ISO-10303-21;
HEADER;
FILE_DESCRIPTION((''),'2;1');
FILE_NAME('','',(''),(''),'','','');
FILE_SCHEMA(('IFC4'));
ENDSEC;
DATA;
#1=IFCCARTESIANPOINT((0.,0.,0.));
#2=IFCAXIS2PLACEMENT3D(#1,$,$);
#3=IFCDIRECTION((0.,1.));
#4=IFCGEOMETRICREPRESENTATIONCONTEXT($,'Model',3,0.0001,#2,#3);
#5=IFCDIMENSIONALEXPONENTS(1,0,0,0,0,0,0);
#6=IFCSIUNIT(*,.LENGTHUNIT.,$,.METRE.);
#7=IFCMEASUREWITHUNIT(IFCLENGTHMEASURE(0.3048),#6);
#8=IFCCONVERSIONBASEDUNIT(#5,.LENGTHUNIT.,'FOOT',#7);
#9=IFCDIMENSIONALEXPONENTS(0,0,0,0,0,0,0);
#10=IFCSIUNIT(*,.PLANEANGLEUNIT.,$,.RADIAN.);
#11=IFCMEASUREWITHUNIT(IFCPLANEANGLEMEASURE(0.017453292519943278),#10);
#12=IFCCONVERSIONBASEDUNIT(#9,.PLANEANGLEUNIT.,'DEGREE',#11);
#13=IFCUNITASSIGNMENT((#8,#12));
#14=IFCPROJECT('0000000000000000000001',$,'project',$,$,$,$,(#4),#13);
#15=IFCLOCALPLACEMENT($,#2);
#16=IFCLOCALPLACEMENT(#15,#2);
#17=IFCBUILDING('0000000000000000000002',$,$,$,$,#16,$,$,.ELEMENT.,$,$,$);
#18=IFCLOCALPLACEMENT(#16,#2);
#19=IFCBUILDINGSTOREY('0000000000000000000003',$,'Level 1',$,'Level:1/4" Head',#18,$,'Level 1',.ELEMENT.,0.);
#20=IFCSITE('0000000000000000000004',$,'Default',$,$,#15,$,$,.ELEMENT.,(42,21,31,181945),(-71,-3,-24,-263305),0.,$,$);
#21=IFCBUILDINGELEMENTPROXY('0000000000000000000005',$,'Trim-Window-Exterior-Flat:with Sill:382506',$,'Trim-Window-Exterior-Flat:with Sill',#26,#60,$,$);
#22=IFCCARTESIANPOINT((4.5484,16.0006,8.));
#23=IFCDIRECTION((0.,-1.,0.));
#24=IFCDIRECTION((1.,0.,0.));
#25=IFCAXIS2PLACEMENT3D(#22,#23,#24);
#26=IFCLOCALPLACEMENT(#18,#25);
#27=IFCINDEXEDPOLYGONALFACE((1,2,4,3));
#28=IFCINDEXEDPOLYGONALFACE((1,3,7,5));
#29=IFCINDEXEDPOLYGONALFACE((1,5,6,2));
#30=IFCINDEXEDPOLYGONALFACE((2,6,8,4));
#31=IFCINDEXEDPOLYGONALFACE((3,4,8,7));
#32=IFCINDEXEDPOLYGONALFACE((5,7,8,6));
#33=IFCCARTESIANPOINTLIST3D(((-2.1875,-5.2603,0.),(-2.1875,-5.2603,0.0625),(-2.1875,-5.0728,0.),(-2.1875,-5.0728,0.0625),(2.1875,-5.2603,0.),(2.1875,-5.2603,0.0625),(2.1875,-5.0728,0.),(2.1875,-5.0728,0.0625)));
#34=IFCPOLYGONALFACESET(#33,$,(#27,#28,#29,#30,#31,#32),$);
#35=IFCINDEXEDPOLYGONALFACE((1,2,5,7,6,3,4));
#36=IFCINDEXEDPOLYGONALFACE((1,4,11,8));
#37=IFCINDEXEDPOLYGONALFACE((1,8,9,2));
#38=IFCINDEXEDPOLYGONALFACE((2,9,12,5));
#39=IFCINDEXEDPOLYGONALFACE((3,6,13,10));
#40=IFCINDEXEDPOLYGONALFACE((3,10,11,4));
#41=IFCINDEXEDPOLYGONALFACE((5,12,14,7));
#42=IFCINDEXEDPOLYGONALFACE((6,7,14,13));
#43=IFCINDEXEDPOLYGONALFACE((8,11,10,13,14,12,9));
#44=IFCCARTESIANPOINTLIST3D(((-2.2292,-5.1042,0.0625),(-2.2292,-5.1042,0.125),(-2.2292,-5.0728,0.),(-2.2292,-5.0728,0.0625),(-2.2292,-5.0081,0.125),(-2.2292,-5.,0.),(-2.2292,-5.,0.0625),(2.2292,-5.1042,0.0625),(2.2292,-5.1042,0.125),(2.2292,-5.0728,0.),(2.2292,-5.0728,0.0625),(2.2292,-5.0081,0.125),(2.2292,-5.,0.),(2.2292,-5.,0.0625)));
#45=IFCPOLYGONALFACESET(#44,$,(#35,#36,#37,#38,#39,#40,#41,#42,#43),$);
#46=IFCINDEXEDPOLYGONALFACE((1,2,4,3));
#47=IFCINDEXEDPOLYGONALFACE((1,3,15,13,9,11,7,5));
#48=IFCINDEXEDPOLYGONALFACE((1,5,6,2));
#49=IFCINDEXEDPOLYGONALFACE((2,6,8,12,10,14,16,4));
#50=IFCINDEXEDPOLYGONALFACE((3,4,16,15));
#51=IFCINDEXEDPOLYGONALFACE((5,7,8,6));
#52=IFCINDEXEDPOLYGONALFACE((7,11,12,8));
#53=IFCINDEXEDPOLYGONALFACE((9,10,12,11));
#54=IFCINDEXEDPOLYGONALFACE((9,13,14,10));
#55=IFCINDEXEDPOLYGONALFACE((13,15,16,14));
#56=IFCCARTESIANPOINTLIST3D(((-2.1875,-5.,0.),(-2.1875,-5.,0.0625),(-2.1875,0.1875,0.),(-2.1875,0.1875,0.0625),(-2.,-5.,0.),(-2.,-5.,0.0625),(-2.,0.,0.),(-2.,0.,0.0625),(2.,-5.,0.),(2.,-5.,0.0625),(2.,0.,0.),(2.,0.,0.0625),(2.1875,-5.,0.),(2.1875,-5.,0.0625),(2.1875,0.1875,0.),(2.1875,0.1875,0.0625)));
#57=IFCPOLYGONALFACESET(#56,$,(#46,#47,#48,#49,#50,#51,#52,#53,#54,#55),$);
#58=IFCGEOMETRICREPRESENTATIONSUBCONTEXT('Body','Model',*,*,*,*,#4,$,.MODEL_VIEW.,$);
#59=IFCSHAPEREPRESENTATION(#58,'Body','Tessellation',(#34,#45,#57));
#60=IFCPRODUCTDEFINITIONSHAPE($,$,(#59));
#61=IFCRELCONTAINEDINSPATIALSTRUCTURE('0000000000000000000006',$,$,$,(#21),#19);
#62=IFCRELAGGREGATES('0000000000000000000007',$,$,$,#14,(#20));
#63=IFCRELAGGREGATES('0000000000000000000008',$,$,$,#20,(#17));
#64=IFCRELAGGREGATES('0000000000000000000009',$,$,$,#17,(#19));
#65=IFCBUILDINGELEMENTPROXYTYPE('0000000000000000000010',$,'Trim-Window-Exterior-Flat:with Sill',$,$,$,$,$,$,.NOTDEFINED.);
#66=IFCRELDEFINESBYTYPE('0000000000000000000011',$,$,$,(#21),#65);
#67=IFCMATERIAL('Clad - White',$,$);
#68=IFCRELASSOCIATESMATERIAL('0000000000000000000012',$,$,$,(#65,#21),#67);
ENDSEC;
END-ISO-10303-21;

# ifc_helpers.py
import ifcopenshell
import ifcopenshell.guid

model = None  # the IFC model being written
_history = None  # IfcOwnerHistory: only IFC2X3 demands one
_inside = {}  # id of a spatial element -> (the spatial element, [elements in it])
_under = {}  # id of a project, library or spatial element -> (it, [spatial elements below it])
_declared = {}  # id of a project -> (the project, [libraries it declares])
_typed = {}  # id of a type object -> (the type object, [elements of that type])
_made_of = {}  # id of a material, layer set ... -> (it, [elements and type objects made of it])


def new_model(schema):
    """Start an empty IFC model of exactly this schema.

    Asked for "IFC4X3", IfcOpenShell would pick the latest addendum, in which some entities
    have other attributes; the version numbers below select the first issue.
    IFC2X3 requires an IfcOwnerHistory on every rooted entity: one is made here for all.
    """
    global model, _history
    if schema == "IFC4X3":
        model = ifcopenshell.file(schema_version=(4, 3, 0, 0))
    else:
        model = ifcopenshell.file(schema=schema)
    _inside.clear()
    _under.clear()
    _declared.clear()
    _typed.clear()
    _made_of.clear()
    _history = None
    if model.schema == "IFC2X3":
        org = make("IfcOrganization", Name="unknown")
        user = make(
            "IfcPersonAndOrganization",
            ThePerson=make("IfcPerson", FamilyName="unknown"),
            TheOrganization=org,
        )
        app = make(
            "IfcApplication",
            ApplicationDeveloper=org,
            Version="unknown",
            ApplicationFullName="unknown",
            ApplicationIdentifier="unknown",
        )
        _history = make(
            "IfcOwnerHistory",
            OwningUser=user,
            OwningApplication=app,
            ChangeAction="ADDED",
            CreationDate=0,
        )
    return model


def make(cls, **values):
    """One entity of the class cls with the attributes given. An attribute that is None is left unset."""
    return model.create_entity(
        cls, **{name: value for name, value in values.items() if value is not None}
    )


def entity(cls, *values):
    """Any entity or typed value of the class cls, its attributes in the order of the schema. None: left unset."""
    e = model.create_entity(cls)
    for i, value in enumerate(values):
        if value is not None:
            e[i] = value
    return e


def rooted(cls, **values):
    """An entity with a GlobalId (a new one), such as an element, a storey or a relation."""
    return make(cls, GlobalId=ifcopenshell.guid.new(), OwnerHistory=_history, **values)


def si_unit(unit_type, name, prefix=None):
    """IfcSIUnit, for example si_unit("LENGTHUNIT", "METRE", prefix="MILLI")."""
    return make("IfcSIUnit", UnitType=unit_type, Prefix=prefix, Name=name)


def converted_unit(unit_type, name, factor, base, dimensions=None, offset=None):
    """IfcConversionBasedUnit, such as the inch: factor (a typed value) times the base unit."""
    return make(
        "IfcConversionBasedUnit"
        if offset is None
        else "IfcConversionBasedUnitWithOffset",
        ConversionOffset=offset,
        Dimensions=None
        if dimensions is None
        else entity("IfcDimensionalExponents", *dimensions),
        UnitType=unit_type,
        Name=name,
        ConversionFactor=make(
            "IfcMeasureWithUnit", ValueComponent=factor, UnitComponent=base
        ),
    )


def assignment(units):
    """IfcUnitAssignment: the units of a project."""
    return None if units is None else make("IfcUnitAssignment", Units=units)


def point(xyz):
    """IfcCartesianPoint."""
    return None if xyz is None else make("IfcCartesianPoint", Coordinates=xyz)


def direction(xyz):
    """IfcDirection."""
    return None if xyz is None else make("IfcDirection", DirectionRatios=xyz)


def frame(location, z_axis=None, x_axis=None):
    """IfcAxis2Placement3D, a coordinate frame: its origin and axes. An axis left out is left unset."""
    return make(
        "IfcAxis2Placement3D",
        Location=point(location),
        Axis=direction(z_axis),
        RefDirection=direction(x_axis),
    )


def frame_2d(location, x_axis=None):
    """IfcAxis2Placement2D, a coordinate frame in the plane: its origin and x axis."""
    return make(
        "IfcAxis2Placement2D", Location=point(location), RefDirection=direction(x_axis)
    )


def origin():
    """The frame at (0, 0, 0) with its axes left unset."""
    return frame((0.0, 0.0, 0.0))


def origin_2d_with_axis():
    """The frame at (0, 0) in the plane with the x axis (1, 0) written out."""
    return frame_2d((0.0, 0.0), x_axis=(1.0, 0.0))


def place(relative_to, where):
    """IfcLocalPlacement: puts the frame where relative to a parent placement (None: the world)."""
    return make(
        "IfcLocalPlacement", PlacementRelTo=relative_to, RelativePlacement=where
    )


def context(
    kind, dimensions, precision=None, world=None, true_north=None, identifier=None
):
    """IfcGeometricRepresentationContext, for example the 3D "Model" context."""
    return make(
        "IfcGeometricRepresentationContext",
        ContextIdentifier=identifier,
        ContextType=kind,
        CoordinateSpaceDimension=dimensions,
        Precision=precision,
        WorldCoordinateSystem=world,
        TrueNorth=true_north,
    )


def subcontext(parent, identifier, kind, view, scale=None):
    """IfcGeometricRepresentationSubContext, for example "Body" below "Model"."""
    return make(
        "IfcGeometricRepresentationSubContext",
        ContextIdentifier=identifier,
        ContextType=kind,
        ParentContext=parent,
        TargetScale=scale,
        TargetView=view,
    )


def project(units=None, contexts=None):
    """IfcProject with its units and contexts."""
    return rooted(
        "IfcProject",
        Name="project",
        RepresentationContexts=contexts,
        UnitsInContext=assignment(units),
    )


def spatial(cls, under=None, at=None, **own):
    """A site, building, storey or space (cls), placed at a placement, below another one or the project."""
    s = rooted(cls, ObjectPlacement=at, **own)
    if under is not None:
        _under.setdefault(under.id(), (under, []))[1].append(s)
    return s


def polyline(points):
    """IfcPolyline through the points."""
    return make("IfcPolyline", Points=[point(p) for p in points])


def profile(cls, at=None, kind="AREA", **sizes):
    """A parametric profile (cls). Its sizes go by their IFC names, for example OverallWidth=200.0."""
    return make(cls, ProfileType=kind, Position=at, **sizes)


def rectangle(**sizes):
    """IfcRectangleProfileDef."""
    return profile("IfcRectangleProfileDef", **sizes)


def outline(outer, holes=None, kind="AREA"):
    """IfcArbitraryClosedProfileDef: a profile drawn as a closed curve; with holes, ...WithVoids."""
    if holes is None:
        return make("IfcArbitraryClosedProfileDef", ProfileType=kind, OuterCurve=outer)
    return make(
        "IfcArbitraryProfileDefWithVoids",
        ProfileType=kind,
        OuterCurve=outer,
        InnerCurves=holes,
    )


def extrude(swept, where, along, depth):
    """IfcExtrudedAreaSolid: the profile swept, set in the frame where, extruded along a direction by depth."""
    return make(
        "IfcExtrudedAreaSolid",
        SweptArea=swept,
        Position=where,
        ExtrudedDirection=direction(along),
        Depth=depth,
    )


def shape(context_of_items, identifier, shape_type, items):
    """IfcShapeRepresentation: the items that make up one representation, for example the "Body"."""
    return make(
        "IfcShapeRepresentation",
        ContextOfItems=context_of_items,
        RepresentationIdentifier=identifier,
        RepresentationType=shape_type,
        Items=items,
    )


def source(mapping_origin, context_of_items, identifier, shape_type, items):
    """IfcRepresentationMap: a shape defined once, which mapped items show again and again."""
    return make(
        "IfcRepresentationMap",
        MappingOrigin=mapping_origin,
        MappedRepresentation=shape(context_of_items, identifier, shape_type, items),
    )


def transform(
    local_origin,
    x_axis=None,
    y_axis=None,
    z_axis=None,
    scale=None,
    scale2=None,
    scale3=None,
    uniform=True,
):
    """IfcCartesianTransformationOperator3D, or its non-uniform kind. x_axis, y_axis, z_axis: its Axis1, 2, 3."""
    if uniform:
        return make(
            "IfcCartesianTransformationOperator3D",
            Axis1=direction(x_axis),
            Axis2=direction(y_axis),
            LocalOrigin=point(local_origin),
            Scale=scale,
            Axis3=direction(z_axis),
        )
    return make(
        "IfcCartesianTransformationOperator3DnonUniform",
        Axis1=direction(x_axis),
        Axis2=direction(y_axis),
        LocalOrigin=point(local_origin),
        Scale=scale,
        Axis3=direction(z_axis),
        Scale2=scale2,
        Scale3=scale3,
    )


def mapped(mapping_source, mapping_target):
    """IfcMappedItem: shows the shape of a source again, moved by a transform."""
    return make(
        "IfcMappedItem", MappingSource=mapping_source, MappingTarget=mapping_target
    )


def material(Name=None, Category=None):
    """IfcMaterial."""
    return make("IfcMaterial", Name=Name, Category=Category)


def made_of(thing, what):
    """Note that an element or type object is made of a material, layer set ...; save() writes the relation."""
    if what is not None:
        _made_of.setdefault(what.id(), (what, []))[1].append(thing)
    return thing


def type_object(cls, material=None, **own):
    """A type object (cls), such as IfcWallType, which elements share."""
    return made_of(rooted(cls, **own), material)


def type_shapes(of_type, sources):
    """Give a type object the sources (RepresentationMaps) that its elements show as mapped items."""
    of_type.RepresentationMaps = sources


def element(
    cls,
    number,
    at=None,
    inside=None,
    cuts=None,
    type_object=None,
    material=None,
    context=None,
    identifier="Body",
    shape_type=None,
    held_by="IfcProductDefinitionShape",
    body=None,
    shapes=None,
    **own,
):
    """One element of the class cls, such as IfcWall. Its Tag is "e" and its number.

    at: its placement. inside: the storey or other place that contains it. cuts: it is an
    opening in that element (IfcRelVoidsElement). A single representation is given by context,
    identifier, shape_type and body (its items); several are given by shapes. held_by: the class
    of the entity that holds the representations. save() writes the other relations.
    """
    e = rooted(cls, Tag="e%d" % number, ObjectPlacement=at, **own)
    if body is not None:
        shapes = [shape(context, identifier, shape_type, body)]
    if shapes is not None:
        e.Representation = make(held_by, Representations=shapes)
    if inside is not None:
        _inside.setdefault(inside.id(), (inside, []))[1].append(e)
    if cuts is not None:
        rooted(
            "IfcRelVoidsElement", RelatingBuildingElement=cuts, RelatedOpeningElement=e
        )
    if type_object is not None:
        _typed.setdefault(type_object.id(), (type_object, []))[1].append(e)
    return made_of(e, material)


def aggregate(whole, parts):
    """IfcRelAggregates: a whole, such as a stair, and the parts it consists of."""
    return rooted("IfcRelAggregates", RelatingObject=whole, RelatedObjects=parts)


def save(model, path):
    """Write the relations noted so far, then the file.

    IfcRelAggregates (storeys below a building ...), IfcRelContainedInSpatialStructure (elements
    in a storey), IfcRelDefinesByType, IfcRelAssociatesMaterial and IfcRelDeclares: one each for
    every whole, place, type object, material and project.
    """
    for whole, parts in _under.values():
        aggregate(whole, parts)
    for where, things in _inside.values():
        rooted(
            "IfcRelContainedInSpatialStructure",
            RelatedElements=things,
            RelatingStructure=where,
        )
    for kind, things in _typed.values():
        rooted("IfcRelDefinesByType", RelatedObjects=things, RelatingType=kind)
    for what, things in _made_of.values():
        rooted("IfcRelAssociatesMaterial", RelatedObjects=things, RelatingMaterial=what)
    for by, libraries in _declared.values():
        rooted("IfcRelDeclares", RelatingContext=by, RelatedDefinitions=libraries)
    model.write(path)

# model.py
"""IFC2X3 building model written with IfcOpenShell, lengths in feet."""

from ifc_helpers import new_model, entity, si_unit, converted_unit, direction, frame, origin, origin_2d_with_axis, place, context, subcontext, project, spatial, polyline, rectangle, outline, extrude, source, transform, mapped, material, type_object, type_shapes, element, save


model = new_model("IFC2X3")

# Units and contexts
model_context = context("Model", 3, precision=0.0001, world=origin(), true_north=direction((0.0, 1.0)))
body_context = subcontext(model_context, "Body", "Model", "MODEL_VIEW")
ifc_project = project(units=[converted_unit("LENGTHUNIT", "FOOT", entity("IfcLengthMeasure", 0.3048), si_unit("LENGTHUNIT", "METRE"), dimensions=[1, 0, 0, 0, 0, 0, 0]), converted_unit("PLANEANGLEUNIT", "DEGREE", entity("IfcPlaneAngleMeasure", 0.017453292519943278), si_unit("PLANEANGLEUNIT", "RADIAN"), dimensions=[0, 0, 0, 0, 0, 0, 0])], contexts=[model_context])

# Site, building, storey
site_placement = place(None, origin())
site = spatial("IfcSite", under=ifc_project, at=site_placement, Name="Default", CompositionType="ELEMENT", RefLatitude=(42, 21, 31, 181945), RefLongitude=(-71, -3, -24, -263305), RefElevation=0.0)
building_placement = place(site_placement, origin())
building = spatial("IfcBuilding", under=site, at=building_placement, CompositionType="ELEMENT")
storey_placement = place(building_placement, origin())
storey = spatial("IfcBuildingStorey", under=building, at=storey_placement, Name="Level 1", ObjectType="Level:1/4\" Head", LongName="Level 1", CompositionType="ELEMENT", Elevation=0.0)

# Building element proxy
ifc_material_1 = material(Name="Clad - White")
building_element_proxy_type_1 = type_object("IfcBuildingElementProxyType", Name="Trim-Window-Exterior-Flat:with Sill", PredefinedType="NOTDEFINED", material=ifc_material_1)
shared_shape_1 = source(origin(), body_context, "Body", "SweptSolid", [
    extrude(rectangle(XDim=4.375, YDim=0.1875, at=origin_2d_with_axis()), frame((0.0, -5.1665, 0.0), z_axis=(0.0, 0.0, 1.0), x_axis=(-1.0, 0.0, 0.0)), (0.0, 0.0, 1.0), 0.0625),
    extrude(outline(polyline([(-0.0625, -0.0525), (0.0, -0.0525), (0.0, -0.0211), (0.0625, -0.0211), (0.0625, 0.0517), (0.0, 0.0517), (-0.0625, 0.0436), (-0.0625, -0.0525)])), frame((-2.2292, -5.0517, 0.0625), z_axis=(1.0, 0.0, 0.0), x_axis=(0.0, 0.0, -1.0)), (0.0, 0.0, 1.0), 4.4583),
    extrude(outline(polyline([(-2.6406, -2.1875), (2.5469, -2.1875), (2.5469, -2.0), (-2.4531, -2.0), (-2.4531, 2.0), (2.5469, 2.0), (2.5469, 2.1875), (-2.6406, 2.1875), (-2.6406, -2.1875)])), frame((0.0, -2.4531, 0.0), z_axis=(0.0, 0.0, 1.0), x_axis=(0.0, -1.0, 0.0)), (0.0, 0.0, 1.0), 0.0625),
])
type_shapes(building_element_proxy_type_1, [shared_shape_1])
proxy_1_placement = place(storey_placement, frame((4.5484, 16.0006, 8.0), z_axis=(0.0, -1.0, 0.0), x_axis=(1.0, 0.0, 0.0)))
element("IfcBuildingElementProxy", 1, at=proxy_1_placement, inside=storey, type_object=building_element_proxy_type_1, material=ifc_material_1, Name="Trim-Window-Exterior-Flat:with Sill:382506", ObjectType="Trim-Window-Exterior-Flat:with Sill", context=body_context, shape_type="MappedRepresentation", body=[
    mapped(shared_shape_1, transform((0.0, 0.0, 0.0), scale=1.0)),
])

save(model, "model.ifc")
